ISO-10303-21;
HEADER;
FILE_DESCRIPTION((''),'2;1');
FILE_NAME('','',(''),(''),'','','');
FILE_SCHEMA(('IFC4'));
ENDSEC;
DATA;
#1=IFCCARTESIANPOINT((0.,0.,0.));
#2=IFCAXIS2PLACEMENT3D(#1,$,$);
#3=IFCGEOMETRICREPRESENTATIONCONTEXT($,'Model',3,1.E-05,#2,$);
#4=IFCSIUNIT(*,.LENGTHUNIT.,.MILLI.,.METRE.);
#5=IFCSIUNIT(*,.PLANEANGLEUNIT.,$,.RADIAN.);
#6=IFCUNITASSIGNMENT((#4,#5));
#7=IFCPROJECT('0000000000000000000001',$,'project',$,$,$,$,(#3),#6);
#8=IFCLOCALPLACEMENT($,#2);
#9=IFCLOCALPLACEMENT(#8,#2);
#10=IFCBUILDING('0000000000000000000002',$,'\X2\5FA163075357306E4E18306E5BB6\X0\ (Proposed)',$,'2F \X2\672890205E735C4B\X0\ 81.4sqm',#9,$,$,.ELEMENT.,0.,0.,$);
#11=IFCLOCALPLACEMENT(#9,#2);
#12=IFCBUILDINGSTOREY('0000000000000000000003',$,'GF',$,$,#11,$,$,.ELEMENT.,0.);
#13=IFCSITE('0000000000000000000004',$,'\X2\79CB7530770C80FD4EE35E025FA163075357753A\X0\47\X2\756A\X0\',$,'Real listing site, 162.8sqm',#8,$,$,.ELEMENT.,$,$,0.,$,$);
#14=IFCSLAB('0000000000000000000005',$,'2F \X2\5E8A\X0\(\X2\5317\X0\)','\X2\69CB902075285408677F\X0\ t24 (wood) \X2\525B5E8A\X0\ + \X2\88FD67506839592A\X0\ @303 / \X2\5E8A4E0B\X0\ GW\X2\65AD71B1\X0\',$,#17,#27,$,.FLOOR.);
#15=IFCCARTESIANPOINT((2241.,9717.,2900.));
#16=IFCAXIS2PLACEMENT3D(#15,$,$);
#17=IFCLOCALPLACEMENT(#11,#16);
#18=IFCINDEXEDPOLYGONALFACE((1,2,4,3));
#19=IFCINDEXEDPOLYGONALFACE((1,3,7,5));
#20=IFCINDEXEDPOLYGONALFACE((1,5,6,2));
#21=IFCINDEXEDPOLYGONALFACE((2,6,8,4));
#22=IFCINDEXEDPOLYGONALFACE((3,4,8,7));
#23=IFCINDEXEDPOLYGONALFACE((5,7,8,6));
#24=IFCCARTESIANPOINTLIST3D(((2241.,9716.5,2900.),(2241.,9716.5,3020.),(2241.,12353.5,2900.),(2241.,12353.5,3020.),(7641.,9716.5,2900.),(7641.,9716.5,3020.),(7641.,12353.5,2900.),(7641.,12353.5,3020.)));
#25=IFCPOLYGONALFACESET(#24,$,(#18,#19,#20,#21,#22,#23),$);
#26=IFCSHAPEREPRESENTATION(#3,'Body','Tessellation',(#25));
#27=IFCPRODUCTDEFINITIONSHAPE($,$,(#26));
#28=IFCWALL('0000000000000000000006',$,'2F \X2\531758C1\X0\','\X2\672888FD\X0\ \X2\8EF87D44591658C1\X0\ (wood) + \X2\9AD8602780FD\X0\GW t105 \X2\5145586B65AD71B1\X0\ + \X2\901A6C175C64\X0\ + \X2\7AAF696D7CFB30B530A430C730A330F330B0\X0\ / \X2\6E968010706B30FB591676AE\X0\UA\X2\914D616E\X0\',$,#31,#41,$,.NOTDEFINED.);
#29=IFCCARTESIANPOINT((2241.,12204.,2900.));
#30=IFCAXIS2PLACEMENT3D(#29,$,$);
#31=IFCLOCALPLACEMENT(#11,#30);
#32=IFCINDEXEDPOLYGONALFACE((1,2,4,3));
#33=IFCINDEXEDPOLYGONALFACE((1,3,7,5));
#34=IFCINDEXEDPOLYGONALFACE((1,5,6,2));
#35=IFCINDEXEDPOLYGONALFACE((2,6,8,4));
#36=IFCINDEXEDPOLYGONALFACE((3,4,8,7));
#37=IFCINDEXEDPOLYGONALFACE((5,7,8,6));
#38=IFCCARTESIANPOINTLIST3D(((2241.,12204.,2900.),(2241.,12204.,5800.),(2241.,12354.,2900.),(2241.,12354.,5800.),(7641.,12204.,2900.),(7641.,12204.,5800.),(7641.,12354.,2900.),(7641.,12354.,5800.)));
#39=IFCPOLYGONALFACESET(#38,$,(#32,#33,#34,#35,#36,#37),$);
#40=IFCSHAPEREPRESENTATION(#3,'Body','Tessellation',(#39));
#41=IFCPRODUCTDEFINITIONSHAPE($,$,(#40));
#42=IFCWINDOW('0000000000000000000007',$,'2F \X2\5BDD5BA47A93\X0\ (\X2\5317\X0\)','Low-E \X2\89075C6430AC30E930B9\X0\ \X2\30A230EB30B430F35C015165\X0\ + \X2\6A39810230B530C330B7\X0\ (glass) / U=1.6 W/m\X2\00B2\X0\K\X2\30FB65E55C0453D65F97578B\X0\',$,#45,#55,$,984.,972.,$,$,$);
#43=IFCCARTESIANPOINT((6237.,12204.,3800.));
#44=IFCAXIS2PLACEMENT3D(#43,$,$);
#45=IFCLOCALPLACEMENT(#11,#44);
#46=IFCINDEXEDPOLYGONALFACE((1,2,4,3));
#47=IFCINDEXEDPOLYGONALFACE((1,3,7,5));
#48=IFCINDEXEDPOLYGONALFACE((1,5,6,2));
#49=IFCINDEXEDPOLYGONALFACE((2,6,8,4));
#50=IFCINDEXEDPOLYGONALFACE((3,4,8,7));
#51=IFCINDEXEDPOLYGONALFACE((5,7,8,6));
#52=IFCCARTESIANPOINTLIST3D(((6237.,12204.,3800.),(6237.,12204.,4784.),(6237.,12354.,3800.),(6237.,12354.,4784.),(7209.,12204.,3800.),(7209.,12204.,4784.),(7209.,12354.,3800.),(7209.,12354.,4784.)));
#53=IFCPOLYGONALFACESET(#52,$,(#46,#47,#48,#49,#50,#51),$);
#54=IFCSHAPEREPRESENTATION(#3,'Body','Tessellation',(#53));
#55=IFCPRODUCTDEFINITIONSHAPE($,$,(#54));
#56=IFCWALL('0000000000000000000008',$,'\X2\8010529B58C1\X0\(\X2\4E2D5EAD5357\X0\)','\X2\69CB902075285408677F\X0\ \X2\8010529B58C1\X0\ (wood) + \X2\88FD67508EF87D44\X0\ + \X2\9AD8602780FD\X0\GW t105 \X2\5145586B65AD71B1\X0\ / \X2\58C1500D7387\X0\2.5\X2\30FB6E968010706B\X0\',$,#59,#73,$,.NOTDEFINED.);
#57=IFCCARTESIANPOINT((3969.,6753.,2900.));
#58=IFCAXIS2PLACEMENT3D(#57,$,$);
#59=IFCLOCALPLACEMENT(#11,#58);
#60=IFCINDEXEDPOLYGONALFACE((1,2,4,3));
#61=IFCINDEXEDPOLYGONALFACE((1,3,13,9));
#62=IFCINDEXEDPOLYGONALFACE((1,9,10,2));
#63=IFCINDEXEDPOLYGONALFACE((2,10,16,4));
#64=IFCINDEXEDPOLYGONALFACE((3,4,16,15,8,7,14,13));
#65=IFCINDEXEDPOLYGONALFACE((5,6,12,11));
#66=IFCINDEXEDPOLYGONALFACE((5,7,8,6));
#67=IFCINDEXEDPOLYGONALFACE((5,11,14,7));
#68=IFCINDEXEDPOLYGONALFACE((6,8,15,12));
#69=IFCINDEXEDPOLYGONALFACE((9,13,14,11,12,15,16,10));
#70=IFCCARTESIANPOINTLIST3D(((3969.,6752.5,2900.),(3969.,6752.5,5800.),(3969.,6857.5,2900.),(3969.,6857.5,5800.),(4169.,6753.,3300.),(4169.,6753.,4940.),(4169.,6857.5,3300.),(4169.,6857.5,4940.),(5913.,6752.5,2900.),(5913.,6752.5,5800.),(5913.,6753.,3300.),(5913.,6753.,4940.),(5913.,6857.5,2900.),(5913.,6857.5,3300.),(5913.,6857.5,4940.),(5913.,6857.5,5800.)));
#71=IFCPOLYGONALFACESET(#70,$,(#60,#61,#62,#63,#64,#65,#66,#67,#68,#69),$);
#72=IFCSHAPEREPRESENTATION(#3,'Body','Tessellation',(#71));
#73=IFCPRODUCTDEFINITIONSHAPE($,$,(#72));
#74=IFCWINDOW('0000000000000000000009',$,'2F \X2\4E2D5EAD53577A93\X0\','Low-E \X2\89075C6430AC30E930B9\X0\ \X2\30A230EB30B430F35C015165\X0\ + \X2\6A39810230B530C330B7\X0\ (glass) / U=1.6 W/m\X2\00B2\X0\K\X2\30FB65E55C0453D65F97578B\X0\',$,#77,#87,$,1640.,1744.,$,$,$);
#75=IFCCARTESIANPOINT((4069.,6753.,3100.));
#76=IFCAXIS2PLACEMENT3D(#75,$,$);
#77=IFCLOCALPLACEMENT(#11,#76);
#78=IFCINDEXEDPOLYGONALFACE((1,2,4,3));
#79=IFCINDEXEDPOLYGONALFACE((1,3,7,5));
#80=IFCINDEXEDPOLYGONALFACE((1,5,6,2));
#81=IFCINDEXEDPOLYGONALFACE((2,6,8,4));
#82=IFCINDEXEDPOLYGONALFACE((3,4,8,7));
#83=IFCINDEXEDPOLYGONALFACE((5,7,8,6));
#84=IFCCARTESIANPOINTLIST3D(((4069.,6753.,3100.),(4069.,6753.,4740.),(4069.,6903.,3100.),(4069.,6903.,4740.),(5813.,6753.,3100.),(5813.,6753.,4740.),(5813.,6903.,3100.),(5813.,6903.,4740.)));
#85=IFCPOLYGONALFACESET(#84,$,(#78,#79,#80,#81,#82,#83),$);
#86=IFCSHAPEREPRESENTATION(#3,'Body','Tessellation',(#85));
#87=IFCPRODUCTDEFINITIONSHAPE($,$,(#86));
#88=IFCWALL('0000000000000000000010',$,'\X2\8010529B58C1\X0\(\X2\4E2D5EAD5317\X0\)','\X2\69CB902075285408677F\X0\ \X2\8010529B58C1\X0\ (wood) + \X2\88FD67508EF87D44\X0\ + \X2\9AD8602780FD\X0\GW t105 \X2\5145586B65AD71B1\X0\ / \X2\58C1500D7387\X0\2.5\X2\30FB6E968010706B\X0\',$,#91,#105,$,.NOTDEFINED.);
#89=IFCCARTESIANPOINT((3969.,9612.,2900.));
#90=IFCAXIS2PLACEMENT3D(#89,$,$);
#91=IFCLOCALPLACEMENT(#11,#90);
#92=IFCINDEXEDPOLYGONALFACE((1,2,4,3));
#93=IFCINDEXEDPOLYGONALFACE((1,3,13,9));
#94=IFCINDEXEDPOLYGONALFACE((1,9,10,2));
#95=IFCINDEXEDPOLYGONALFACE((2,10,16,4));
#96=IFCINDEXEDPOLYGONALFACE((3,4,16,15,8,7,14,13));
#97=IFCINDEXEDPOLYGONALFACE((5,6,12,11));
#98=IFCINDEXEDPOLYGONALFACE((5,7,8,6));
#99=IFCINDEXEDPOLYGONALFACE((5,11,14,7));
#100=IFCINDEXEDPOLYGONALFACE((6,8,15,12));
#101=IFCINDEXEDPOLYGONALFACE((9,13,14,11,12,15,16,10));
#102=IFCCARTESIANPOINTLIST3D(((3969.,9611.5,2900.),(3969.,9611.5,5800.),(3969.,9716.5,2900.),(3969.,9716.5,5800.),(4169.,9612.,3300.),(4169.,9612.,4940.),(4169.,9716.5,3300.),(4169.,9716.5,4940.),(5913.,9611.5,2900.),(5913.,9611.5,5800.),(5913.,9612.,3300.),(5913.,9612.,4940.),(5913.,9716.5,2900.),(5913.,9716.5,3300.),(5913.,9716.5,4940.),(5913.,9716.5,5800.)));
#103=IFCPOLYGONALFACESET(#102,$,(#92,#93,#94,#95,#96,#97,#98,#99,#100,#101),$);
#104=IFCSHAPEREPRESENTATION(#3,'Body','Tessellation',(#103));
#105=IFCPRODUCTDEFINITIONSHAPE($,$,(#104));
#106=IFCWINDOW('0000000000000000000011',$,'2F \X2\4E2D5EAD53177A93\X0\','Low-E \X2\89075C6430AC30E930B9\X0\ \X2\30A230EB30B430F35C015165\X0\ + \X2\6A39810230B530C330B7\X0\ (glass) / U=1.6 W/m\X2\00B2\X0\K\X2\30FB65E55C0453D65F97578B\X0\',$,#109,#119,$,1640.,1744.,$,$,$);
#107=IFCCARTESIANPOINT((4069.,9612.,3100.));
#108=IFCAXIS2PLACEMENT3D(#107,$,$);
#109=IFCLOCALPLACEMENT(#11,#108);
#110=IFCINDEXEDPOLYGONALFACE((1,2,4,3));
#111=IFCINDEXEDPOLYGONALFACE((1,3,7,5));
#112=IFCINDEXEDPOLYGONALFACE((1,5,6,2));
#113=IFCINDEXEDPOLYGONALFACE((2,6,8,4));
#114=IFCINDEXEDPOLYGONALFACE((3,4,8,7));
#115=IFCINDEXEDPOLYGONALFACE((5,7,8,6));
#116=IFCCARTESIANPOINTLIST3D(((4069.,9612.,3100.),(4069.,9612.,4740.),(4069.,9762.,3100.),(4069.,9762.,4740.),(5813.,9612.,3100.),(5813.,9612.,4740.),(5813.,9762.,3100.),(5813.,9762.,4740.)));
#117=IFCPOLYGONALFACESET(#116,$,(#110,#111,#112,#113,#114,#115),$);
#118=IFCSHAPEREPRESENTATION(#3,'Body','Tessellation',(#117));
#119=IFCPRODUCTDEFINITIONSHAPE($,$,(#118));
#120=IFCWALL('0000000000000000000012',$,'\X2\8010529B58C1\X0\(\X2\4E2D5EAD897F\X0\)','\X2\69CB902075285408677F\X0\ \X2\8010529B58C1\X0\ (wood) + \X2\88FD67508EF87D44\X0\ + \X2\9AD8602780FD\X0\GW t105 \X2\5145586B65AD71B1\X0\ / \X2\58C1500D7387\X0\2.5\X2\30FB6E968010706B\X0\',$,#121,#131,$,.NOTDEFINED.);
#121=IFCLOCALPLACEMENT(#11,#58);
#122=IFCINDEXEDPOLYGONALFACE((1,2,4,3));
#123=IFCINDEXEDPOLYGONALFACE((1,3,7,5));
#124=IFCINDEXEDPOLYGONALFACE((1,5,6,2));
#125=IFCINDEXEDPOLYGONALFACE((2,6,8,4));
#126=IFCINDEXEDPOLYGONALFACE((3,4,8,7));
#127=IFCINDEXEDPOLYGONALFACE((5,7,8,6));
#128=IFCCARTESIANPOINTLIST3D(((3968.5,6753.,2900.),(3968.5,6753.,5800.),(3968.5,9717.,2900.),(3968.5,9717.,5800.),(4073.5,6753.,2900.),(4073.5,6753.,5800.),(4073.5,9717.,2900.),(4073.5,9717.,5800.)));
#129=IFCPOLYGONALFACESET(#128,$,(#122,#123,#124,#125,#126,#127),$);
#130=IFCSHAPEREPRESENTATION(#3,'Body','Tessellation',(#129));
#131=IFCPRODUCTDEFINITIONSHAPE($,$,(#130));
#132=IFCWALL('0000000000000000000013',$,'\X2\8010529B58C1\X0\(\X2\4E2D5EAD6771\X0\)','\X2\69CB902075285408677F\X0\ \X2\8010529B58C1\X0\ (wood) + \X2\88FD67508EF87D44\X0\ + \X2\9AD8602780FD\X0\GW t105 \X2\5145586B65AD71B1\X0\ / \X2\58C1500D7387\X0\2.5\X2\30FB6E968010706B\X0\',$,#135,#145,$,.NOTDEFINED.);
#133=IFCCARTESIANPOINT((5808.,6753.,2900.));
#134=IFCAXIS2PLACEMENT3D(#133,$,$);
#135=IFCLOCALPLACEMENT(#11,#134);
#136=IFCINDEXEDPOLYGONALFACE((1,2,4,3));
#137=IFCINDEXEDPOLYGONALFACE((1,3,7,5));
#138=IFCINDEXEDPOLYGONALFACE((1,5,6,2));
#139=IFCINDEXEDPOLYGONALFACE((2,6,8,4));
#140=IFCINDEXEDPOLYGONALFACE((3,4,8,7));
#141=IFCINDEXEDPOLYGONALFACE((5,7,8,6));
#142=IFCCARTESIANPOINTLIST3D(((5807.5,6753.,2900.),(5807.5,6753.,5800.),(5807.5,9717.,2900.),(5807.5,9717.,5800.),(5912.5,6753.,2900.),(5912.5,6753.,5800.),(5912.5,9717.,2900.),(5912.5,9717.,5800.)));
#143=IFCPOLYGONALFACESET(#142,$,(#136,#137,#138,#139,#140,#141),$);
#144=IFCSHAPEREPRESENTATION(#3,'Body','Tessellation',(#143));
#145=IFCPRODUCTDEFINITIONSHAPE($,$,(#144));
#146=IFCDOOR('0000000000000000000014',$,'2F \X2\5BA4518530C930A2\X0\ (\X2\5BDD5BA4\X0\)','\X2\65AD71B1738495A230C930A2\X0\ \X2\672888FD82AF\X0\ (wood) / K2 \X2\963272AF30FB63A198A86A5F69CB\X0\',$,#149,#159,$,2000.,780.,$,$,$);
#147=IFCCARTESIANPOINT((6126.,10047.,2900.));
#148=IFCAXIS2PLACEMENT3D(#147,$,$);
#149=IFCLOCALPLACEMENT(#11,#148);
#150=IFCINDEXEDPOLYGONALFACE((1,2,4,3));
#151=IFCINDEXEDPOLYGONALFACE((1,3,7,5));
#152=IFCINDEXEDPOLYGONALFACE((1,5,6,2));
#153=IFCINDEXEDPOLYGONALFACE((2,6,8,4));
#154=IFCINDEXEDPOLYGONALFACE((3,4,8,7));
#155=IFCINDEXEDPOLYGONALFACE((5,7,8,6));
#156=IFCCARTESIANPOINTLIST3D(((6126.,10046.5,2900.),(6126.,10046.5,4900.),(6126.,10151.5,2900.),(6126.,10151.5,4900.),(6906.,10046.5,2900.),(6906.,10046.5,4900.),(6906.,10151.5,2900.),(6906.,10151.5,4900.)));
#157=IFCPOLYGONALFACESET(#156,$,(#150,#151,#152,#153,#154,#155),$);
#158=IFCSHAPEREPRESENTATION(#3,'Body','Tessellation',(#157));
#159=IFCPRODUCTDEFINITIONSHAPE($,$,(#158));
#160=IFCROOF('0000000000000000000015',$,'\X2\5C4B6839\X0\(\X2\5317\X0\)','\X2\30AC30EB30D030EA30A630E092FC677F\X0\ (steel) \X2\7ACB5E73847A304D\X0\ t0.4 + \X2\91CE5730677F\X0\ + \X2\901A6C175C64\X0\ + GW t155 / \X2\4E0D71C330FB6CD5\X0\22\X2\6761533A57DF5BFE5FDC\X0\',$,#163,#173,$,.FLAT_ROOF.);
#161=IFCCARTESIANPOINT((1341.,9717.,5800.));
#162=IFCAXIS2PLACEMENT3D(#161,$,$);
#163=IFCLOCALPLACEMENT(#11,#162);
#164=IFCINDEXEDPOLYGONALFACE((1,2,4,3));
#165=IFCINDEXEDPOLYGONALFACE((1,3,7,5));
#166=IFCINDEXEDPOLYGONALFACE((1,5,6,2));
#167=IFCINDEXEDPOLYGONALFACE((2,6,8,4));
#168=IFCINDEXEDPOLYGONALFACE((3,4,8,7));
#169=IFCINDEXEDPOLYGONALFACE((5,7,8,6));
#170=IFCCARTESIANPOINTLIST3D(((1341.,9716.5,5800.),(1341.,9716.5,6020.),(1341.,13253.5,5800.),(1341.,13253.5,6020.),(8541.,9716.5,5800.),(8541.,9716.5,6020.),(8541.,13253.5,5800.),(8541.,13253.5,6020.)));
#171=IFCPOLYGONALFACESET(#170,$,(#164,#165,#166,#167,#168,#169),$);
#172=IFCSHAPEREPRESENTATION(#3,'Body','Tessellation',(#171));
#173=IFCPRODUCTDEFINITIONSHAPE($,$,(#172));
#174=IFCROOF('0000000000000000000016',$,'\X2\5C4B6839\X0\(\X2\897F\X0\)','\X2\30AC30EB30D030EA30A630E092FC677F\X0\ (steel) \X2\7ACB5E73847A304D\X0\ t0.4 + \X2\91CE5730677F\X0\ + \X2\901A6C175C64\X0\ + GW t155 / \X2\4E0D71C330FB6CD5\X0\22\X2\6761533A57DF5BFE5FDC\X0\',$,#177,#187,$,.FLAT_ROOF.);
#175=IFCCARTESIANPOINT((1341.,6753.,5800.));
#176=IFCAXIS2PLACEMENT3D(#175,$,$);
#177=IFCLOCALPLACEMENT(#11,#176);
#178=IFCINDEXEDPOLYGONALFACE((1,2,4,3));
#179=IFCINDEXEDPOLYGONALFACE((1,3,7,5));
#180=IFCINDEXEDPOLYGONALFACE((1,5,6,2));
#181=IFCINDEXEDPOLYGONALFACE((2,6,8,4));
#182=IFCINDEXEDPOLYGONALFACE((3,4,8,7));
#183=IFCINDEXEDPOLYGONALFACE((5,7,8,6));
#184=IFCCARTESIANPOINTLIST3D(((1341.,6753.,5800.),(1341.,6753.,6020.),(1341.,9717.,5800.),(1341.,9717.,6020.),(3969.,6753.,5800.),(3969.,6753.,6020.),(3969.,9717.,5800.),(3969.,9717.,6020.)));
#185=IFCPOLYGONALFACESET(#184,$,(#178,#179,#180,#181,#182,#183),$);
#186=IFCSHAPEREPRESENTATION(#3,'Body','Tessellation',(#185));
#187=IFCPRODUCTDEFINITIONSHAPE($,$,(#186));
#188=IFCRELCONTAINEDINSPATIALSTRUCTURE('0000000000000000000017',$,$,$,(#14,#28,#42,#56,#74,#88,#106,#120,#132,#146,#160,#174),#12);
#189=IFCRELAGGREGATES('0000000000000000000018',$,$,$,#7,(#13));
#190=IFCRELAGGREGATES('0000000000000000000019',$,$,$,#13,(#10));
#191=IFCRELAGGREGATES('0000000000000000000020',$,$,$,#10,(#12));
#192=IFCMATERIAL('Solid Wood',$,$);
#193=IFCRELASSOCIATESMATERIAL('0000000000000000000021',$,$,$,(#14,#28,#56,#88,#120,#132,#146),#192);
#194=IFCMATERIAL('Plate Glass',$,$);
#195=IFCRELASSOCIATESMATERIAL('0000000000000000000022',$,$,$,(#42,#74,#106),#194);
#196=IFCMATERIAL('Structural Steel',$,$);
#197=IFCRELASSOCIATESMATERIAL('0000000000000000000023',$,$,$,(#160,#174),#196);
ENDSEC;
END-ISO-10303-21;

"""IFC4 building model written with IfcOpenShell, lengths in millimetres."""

from ifc_helpers import new_model, si_unit, frame, frame_2d, origin, place, context, project, spatial, rectangle, extrude, material, element, fill, save


model = new_model("IFC4")

# Units and contexts
model_context = context("Model", 3, precision=1e-05, world=origin())
ifc_project = project(units=[si_unit("LENGTHUNIT", "METRE", prefix="MILLI"), si_unit("PLANEANGLEUNIT", "RADIAN")], contexts=[model_context])

# Site, building, storey
site_placement = place(None, origin())
site = spatial("IfcSite", under=ifc_project, at=site_placement, Name="秋田県能代市御指南町47番", ObjectType="Real listing site, 162.8sqm", CompositionType="ELEMENT", RefElevation=0.0)
building_placement = place(site_placement, origin())
building = spatial("IfcBuilding", under=site, at=building_placement, Name="御指南の丘の家 (Proposed)", ObjectType="2F 木造平屋 81.4sqm", CompositionType="ELEMENT", ElevationOfRefHeight=0.0, ElevationOfTerrain=0.0)
storey_placement = place(building_placement, origin())
storey = spatial("IfcBuildingStorey", under=building, at=storey_placement, Name="GF", CompositionType="ELEMENT", Elevation=0.0)

# Slab
ifc_material_1 = material(Name="Solid Wood")
slab_placement = place(storey_placement, frame((2241.0, 9717.0, 2900.0)))
element("IfcSlab", 1, at=slab_placement, inside=storey, material=ifc_material_1, Name="2F 床(北)", Description="構造用合板 t24 (wood) 剛床 + 製材根太 @303 / 床下 GW断熱", PredefinedType="FLOOR", context=model_context, shape_type="SweptSolid", body=[
    extrude(rectangle(XDim=5400.0, YDim=2637.0, at=frame_2d((2700.0, 1318.0))), frame((2241.0, 9717.0, 2900.0)), (0.0, 0.0, 1.0), 120.0),
])

# Walls, openings, windows
wall_1_placement = place(storey_placement, frame((2241.0, 12204.0, 2900.0)))
wall_1 = element("IfcWall", 2, at=wall_1_placement, inside=storey, material=ifc_material_1, Name="2F 北壁", Description="木製 軸組外壁 (wood) + 高性能GW t105 充填断熱 + 通気層 + 窯業系サイディング / 準耐火・外皮UA配慮", PredefinedType="NOTDEFINED", context=model_context, shape_type="SweptSolid", body=[
    extrude(rectangle(XDim=5400.0, YDim=150.0, at=frame_2d((2700.0, 75.0))), frame((2241.0, 12204.0, 2900.0)), (0.0, 0.0, 1.0), 2900.0),
])
opening_1_placement = place(storey_placement, frame((6237.0, 12204.0, 3800.0)))
opening_1 = element("IfcOpeningElement", 3, at=opening_1_placement, cuts=wall_1, PredefinedType="NOTDEFINED", context=model_context, shape_type="SweptSolid", body=[
    extrude(rectangle(XDim=972.0, YDim=150.0, at=frame_2d((486.0, 75.0))), frame((6237.0, 12204.0, 3800.0)), (0.0, 0.0, 1.0), 984.0),
])
ifc_material_2 = material(Name="Plate Glass")
window_1_placement = place(storey_placement, frame((6237.0, 12204.0, 3800.0)))
window_1 = element("IfcWindow", 4, at=window_1_placement, inside=storey, material=ifc_material_2, Name="2F 寝室窓 (北)", Description="Low-E 複層ガラス アルゴン封入 + 樹脂サッシ (glass) / U=1.6 W/m²K・日射取得型", OverallHeight=984.0, OverallWidth=972.0, context=model_context, shape_type="SweptSolid", body=[
    extrude(rectangle(XDim=972.0, YDim=150.0, at=frame_2d((486.0, 75.0))), frame((6237.0, 12204.0, 3800.0)), (0.0, 0.0, 1.0), 984.0),
])
fill(opening_1, window_1)
wall_2_placement = place(storey_placement, frame((3969.0, 6753.0, 2900.0)))
wall_2 = element("IfcWall", 5, at=wall_2_placement, inside=storey, material=ifc_material_1, Name="耐力壁(中庭南)", Description="構造用合板 耐力壁 (wood) + 製材軸組 + 高性能GW t105 充填断熱 / 壁倍率2.5・準耐火", PredefinedType="NOTDEFINED", context=model_context, shape_type="SweptSolid", body=[
    extrude(rectangle(XDim=1944.0, YDim=105.0, at=frame_2d((972.0, 52.0))), frame((3969.0, 6753.0, 2900.0)), (0.0, 0.0, 1.0), 2900.0),
])
opening_2_placement = place(storey_placement, frame((4069.0, 6753.0, 3100.0)))
opening_2 = element("IfcOpeningElement", 6, at=opening_2_placement, cuts=wall_2, PredefinedType="NOTDEFINED", context=model_context, shape_type="SweptSolid", body=[
    extrude(rectangle(XDim=1744.0, YDim=150.0, at=frame_2d((872.0, 75.0))), frame((4069.0, 6753.0, 3100.0)), (0.0, 0.0, 1.0), 1640.0),
])
window_2_placement = place(storey_placement, frame((4069.0, 6753.0, 3100.0)))
window_2 = element("IfcWindow", 7, at=window_2_placement, inside=storey, material=ifc_material_2, Name="2F 中庭南窓", Description="Low-E 複層ガラス アルゴン封入 + 樹脂サッシ (glass) / U=1.6 W/m²K・日射取得型", OverallHeight=1640.0, OverallWidth=1744.0, context=model_context, shape_type="SweptSolid", body=[
    extrude(rectangle(XDim=1744.0, YDim=150.0, at=frame_2d((872.0, 75.0))), frame((4069.0, 6753.0, 3100.0)), (0.0, 0.0, 1.0), 1640.0),
])
fill(opening_2, window_2)
wall_3_placement = place(storey_placement, frame((3969.0, 9612.0, 2900.0)))
wall_3 = element("IfcWall", 8, at=wall_3_placement, inside=storey, material=ifc_material_1, Name="耐力壁(中庭北)", Description="構造用合板 耐力壁 (wood) + 製材軸組 + 高性能GW t105 充填断熱 / 壁倍率2.5・準耐火", PredefinedType="NOTDEFINED", context=model_context, shape_type="SweptSolid", body=[
    extrude(rectangle(XDim=1944.0, YDim=105.0, at=frame_2d((972.0, 52.0))), frame((3969.0, 9612.0, 2900.0)), (0.0, 0.0, 1.0), 2900.0),
])
opening_3_placement = place(storey_placement, frame((4069.0, 9612.0, 3100.0)))
opening_3 = element("IfcOpeningElement", 9, at=opening_3_placement, cuts=wall_3, PredefinedType="NOTDEFINED", context=model_context, shape_type="SweptSolid", body=[
    extrude(rectangle(XDim=1744.0, YDim=150.0, at=frame_2d((872.0, 75.0))), frame((4069.0, 9612.0, 3100.0)), (0.0, 0.0, 1.0), 1640.0),
])
window_3_placement = place(storey_placement, frame((4069.0, 9612.0, 3100.0)))
window_3 = element("IfcWindow", 10, at=window_3_placement, inside=storey, material=ifc_material_2, Name="2F 中庭北窓", Description="Low-E 複層ガラス アルゴン封入 + 樹脂サッシ (glass) / U=1.6 W/m²K・日射取得型", OverallHeight=1640.0, OverallWidth=1744.0, context=model_context, shape_type="SweptSolid", body=[
    extrude(rectangle(XDim=1744.0, YDim=150.0, at=frame_2d((872.0, 75.0))), frame((4069.0, 9612.0, 3100.0)), (0.0, 0.0, 1.0), 1640.0),
])
fill(opening_3, window_3)

# Walls
wall_4_placement = place(storey_placement, frame((3969.0, 6753.0, 2900.0)))
element("IfcWall", 11, at=wall_4_placement, inside=storey, material=ifc_material_1, Name="耐力壁(中庭西)", Description="構造用合板 耐力壁 (wood) + 製材軸組 + 高性能GW t105 充填断熱 / 壁倍率2.5・準耐火", PredefinedType="NOTDEFINED", context=model_context, shape_type="SweptSolid", body=[
    extrude(rectangle(XDim=105.0, YDim=2964.0, at=frame_2d((52.0, 1482.0))), frame((3969.0, 6753.0, 2900.0)), (0.0, 0.0, 1.0), 2900.0),
])
wall_5_placement = place(storey_placement, frame((5808.0, 6753.0, 2900.0)))
element("IfcWall", 12, at=wall_5_placement, inside=storey, material=ifc_material_1, Name="耐力壁(中庭東)", Description="構造用合板 耐力壁 (wood) + 製材軸組 + 高性能GW t105 充填断熱 / 壁倍率2.5・準耐火", PredefinedType="NOTDEFINED", context=model_context, shape_type="SweptSolid", body=[
    extrude(rectangle(XDim=105.0, YDim=2964.0, at=frame_2d((52.0, 1482.0))), frame((5808.0, 6753.0, 2900.0)), (0.0, 0.0, 1.0), 2900.0),
])

# Door
door_placement = place(storey_placement, frame((6126.0, 10047.0, 2900.0)))
element("IfcDoor", 13, at=door_placement, inside=storey, material=ifc_material_1, Name="2F 室内ドア (寝室)", Description="断熱玄関ドア 木製芯 (wood) / K2 防犯・採風機構", OverallHeight=2000.0, OverallWidth=780.0, context=model_context, shape_type="SweptSolid", body=[
    extrude(rectangle(XDim=780.0, YDim=105.0, at=frame_2d((390.0, 52.0))), frame((6126.0, 10047.0, 2900.0)), (0.0, 0.0, 1.0), 2000.0),
])

# Roofs
ifc_material_3 = material(Name="Structural Steel")
for number, where, name in (
    (14, (1341.0, 9717.0, 5800.0), "屋根(北)"),
):
    element("IfcRoof", number, at=place(storey_placement, frame(where)), inside=storey, material=ifc_material_3, Name=name, Description="ガルバリウム鋼板 (steel) 立平葺き t0.4 + 野地板 + 通気層 + GW t155 / 不燃・法22条区域対応", PredefinedType="FLAT_ROOF", context=model_context, shape_type="SweptSolid", body=[
        extrude(rectangle(XDim=7200.0, YDim=3537.0, at=frame_2d((3600.0, 1768.0))), frame((1341.0, 9717.0, 5800.0)), (0.0, 0.0, 1.0), 220.0),
    ])
roof_1_placement = place(storey_placement, frame((1341.0, 6753.0, 5800.0)))
element("IfcRoof", 15, at=roof_1_placement, inside=storey, material=ifc_material_3, Name="屋根(西)", Description="ガルバリウム鋼板 (steel) 立平葺き t0.4 + 野地板 + 通気層 + GW t155 / 不燃・法22条区域対応", PredefinedType="FLAT_ROOF", context=model_context, shape_type="SweptSolid", body=[
    extrude(rectangle(XDim=2628.0, YDim=2964.0, at=frame_2d((1314.0, 1482.0))), frame((1341.0, 6753.0, 5800.0)), (0.0, 0.0, 1.0), 220.0),
])

save(model, "model.ifc")
